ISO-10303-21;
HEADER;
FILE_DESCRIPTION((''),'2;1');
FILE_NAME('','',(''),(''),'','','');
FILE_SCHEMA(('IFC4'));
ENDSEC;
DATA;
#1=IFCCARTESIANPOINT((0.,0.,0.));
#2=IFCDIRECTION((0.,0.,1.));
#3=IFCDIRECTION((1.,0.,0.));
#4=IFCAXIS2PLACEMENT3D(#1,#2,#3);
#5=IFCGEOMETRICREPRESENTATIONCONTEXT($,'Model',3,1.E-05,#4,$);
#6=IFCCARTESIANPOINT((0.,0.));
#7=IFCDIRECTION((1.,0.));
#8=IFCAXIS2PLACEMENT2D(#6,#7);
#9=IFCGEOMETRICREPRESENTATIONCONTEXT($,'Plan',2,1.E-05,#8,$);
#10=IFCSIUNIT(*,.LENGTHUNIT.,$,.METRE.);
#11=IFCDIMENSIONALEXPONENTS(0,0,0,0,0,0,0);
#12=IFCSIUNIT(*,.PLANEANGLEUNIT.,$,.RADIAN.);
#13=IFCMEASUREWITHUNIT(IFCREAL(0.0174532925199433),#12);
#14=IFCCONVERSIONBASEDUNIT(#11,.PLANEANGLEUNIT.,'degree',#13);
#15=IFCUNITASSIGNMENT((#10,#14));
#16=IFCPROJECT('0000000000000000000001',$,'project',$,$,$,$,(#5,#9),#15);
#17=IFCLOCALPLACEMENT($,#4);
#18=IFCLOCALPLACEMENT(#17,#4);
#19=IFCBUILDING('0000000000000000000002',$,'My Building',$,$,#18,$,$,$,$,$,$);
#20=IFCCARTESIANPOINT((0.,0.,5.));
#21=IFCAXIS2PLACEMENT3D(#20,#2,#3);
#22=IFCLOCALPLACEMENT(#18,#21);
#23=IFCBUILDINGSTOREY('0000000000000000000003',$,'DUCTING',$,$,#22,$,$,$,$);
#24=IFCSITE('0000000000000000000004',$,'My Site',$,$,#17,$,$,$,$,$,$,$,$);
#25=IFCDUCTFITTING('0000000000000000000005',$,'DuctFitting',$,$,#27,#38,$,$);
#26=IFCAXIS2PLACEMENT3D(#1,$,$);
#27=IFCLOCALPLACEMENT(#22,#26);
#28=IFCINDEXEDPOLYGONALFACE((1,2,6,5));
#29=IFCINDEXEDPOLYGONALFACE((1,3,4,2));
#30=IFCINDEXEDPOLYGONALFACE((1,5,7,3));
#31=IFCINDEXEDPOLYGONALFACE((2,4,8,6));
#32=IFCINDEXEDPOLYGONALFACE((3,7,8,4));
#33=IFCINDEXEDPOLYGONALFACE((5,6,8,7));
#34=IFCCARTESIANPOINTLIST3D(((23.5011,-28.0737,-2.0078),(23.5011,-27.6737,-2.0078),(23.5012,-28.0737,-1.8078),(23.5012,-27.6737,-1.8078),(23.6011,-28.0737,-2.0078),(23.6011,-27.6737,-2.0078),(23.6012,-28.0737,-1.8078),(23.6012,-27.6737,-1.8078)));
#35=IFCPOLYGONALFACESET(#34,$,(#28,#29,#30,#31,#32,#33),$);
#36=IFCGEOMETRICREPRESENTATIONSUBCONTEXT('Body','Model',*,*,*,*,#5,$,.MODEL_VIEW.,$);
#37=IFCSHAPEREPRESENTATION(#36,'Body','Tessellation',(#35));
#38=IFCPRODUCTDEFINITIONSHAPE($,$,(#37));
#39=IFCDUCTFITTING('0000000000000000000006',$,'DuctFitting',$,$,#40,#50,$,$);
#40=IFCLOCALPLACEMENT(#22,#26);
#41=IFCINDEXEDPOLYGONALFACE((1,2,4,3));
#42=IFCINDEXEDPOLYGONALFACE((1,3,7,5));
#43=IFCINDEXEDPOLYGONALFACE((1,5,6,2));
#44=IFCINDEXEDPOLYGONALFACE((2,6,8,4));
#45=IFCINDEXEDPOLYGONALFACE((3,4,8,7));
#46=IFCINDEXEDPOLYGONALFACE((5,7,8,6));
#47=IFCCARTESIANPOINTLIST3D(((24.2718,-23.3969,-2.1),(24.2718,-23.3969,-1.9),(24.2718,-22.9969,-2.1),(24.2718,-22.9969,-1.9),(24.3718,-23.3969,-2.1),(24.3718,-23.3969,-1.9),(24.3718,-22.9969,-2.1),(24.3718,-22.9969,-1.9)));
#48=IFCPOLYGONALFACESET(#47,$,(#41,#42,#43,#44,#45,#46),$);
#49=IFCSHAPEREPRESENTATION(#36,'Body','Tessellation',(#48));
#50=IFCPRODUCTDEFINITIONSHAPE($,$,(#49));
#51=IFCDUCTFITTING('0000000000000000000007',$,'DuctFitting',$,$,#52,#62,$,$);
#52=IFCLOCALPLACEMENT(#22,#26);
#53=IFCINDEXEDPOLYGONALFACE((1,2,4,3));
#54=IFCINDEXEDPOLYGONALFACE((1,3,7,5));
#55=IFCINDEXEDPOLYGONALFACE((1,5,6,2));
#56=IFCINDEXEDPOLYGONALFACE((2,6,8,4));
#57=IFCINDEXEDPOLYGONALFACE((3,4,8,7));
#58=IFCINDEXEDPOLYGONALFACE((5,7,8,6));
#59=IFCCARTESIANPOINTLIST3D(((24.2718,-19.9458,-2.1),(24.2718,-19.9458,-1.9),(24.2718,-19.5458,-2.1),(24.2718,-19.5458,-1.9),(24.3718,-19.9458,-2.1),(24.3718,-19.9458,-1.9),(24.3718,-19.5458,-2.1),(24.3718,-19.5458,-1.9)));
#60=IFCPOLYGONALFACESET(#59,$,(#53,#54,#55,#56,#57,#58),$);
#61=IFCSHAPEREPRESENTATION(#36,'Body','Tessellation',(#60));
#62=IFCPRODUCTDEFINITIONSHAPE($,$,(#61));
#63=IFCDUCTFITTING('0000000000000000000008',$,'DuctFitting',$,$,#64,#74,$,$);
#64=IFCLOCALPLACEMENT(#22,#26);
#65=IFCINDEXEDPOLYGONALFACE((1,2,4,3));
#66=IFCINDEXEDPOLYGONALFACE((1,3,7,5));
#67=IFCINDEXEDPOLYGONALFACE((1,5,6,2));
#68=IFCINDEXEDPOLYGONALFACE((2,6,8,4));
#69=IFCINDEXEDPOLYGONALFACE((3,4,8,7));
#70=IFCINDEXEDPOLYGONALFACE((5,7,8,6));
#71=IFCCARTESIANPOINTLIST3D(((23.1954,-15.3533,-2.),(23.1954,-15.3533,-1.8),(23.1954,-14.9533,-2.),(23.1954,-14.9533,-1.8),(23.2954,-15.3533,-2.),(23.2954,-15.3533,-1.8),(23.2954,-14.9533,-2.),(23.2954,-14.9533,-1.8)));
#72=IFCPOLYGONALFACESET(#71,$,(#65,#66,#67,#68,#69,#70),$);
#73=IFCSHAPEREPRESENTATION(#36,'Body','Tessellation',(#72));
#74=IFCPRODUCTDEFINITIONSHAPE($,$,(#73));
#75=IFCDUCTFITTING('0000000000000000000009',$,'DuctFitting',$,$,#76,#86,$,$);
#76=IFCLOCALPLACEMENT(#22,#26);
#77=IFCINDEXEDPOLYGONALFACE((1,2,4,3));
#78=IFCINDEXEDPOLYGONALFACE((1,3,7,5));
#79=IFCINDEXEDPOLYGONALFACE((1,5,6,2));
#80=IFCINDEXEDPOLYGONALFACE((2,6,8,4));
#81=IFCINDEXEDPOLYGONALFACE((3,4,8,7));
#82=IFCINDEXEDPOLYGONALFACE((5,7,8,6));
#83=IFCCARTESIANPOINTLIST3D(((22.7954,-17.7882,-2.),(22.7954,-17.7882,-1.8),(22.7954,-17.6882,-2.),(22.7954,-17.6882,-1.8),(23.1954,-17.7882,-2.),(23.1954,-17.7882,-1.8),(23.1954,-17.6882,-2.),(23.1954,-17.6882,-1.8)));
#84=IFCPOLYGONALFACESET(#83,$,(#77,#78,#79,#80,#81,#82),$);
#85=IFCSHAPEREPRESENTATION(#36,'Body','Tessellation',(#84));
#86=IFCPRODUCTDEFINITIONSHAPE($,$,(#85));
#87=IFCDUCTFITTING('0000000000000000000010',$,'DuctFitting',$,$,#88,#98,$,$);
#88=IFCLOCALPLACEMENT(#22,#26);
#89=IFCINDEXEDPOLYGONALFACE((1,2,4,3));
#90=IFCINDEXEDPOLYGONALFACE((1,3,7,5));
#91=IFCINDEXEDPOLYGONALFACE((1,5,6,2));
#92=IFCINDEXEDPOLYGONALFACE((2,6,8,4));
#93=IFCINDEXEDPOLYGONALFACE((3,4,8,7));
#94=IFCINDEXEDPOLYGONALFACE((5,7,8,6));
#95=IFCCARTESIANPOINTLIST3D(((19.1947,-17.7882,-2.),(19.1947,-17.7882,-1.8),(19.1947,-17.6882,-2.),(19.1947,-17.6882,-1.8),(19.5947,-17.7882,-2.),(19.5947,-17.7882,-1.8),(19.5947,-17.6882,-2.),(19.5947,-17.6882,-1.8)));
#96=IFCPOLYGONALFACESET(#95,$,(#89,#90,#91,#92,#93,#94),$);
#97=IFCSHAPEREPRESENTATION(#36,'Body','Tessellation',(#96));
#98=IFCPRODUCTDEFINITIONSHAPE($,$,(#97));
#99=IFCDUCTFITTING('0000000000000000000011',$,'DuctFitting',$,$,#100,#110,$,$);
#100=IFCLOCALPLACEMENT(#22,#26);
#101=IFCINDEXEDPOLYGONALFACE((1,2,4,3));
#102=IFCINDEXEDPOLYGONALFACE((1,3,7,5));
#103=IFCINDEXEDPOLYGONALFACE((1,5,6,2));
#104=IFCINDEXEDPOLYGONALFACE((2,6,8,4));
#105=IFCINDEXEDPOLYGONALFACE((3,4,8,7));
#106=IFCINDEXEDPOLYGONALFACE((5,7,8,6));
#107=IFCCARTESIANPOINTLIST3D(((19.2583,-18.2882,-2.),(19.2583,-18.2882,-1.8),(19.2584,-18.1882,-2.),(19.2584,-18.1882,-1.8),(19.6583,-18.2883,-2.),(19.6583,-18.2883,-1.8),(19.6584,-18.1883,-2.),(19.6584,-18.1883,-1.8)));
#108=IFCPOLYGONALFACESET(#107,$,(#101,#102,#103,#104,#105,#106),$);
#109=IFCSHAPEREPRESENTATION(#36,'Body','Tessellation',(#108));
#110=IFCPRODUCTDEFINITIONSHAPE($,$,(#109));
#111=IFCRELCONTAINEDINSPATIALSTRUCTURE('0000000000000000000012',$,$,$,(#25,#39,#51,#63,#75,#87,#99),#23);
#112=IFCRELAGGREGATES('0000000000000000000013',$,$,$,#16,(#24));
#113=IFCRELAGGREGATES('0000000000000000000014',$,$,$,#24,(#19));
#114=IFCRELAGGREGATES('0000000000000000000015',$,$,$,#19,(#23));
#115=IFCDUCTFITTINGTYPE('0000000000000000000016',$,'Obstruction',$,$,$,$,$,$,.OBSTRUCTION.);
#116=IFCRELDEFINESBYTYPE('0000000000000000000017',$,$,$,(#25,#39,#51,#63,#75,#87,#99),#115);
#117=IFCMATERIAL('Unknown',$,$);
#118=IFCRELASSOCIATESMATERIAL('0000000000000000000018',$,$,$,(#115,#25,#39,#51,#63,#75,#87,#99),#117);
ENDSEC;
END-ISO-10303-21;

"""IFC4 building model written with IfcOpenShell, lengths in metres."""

from ifc_helpers import new_model, entity, si_unit, converted_unit, frame, origin_with_axes, origin_2d_with_axis, place, context, subcontext, project, spatial, rectangle, extrude, material, material_profile, profile_set, profile_usage, type_object, element, save


model = new_model("IFC4")

# Units and contexts
model_context = context("Model", 3, precision=1e-05, world=origin_with_axes())
plan_context = context("Plan", 2, precision=1e-05, world=origin_2d_with_axis())
body_context = subcontext(model_context, "Body", "Model", "MODEL_VIEW")
ifc_project = project(units=[si_unit("LENGTHUNIT", "METRE"), converted_unit("PLANEANGLEUNIT", "degree", entity("IfcReal", 0.0174532925199433), si_unit("PLANEANGLEUNIT", "RADIAN"), dimensions=[0, 0, 0, 0, 0, 0, 0])], contexts=[model_context, plan_context])

# Site, building, storey
site_placement = place(None, origin_with_axes())
site = spatial("IfcSite", under=ifc_project, at=site_placement, Name="My Site")
building_placement = place(site_placement, origin_with_axes())
building = spatial("IfcBuilding", under=site, at=building_placement, Name="My Building")
storey_placement = place(building_placement, frame((0.0, 0.0, 5.0), z_axis=(0.0, 0.0, 1.0), x_axis=(1.0, 0.0, 0.0)))
storey = spatial("IfcBuildingStorey", under=building, at=storey_placement, Name="DUCTING")

# Shared definitions
ifc_material = material(Name="Unknown")

# Duct fittings
ifc_material_profile_1 = material_profile(ifc_material, rectangle(XDim=0.4, YDim=0.2))
ifc_profile_set_1 = profile_set([ifc_material_profile_1])
duct_fitting_type = type_object("IfcDuctFittingType", Name="Obstruction", PredefinedType="OBSTRUCTION", material=ifc_profile_set_1)
ifc_profile_usage_1 = profile_usage(ifc_profile_set_1, cardinal=5)
duct_fitting_1_placement = place(storey_placement, frame((23.5012, -27.8737, -1.9078), z_axis=(1.0, 0.0, -0.000064), x_axis=(0.0, -1.0, 0.0)))
element("IfcDuctFitting", 1, at=duct_fitting_1_placement, inside=storey, type_object=duct_fitting_type, material=ifc_profile_usage_1, Name="DuctFitting", context=body_context, shape_type="SweptSolid", body=[
    extrude(rectangle(XDim=0.4, YDim=0.2), origin_with_axes(), (0.0, 0.0, 1.0), 0.1),
])
ifc_profile_usage_2 = profile_usage(ifc_profile_set_1, cardinal=5)
duct_fitting_2_placement = place(storey_placement, frame((24.2718, -23.1969, -2.0), z_axis=(1.0, 0.0, -0.000064), x_axis=(0.0, -1.0, 0.0)))
element("IfcDuctFitting", 2, at=duct_fitting_2_placement, inside=storey, type_object=duct_fitting_type, material=ifc_profile_usage_2, Name="DuctFitting", context=body_context, shape_type="SweptSolid", body=[
    extrude(rectangle(XDim=0.4, YDim=0.2), origin_with_axes(), (0.0, 0.0, 1.0), 0.1),
])
ifc_profile_usage_3 = profile_usage(ifc_profile_set_1, cardinal=5)
duct_fitting_3_placement = place(storey_placement, frame((24.2718, -19.7458, -2.0), z_axis=(1.0, 0.0, -0.000064), x_axis=(0.0, -1.0, 0.0)))
element("IfcDuctFitting", 3, at=duct_fitting_3_placement, inside=storey, type_object=duct_fitting_type, material=ifc_profile_usage_3, Name="DuctFitting", context=body_context, shape_type="SweptSolid", body=[
    extrude(rectangle(XDim=0.4, YDim=0.2), origin_with_axes(), (0.0, 0.0, 1.0), 0.1),
])
ifc_profile_usage_4 = profile_usage(ifc_profile_set_1, cardinal=5)
duct_fitting_4_placement = place(storey_placement, frame((23.1954, -15.1533, -1.9), z_axis=(1.0, 0.0, 0.0), x_axis=(0.0, -1.0, 0.0)))
element("IfcDuctFitting", 4, at=duct_fitting_4_placement, inside=storey, type_object=duct_fitting_type, material=ifc_profile_usage_4, Name="DuctFitting", context=body_context, shape_type="SweptSolid", body=[
    extrude(rectangle(XDim=0.4, YDim=0.2), origin_with_axes(), (0.0, 0.0, 1.0), 0.1),
])
ifc_profile_usage_5 = profile_usage(ifc_profile_set_1, cardinal=5)
duct_fitting_5_placement = place(storey_placement, frame((22.9954, -17.7882, -1.9), z_axis=(0.0, 1.0, 0.0), x_axis=(-1.0, 0.0, 0.0)))
element("IfcDuctFitting", 5, at=duct_fitting_5_placement, inside=storey, type_object=duct_fitting_type, material=ifc_profile_usage_5, Name="DuctFitting", context=body_context, shape_type="SweptSolid", body=[
    extrude(rectangle(XDim=0.4, YDim=0.2), origin_with_axes(), (0.0, 0.0, 1.0), 0.1),
])
ifc_profile_usage_6 = profile_usage(ifc_profile_set_1, cardinal=5)
duct_fitting_6_placement = place(storey_placement, frame((19.3947, -17.7882, -1.9), z_axis=(0.0, 1.0, 0.0), x_axis=(-1.0, 0.0, 0.0)))
element("IfcDuctFitting", 6, at=duct_fitting_6_placement, inside=storey, type_object=duct_fitting_type, material=ifc_profile_usage_6, Name="DuctFitting", context=body_context, shape_type="SweptSolid", body=[
    extrude(rectangle(XDim=0.4, YDim=0.2), origin_with_axes(), (0.0, 0.0, 1.0), 0.1),
])
ifc_profile_usage_7 = profile_usage(ifc_profile_set_1, cardinal=5)
duct_fitting_7_placement = place(storey_placement, frame((19.4583, -18.2883, -1.9), z_axis=(0.000078, 1.0, 0.0), x_axis=(1.0, -0.000078, 0.0)))
element("IfcDuctFitting", 7, at=duct_fitting_7_placement, inside=storey, type_object=duct_fitting_type, material=ifc_profile_usage_7, Name="DuctFitting", context=body_context, shape_type="SweptSolid", body=[
    extrude(rectangle(XDim=0.4, YDim=0.2), origin_with_axes(), (0.0, 0.0, 1.0), 0.1),
])

save(model, "model.ifc")
